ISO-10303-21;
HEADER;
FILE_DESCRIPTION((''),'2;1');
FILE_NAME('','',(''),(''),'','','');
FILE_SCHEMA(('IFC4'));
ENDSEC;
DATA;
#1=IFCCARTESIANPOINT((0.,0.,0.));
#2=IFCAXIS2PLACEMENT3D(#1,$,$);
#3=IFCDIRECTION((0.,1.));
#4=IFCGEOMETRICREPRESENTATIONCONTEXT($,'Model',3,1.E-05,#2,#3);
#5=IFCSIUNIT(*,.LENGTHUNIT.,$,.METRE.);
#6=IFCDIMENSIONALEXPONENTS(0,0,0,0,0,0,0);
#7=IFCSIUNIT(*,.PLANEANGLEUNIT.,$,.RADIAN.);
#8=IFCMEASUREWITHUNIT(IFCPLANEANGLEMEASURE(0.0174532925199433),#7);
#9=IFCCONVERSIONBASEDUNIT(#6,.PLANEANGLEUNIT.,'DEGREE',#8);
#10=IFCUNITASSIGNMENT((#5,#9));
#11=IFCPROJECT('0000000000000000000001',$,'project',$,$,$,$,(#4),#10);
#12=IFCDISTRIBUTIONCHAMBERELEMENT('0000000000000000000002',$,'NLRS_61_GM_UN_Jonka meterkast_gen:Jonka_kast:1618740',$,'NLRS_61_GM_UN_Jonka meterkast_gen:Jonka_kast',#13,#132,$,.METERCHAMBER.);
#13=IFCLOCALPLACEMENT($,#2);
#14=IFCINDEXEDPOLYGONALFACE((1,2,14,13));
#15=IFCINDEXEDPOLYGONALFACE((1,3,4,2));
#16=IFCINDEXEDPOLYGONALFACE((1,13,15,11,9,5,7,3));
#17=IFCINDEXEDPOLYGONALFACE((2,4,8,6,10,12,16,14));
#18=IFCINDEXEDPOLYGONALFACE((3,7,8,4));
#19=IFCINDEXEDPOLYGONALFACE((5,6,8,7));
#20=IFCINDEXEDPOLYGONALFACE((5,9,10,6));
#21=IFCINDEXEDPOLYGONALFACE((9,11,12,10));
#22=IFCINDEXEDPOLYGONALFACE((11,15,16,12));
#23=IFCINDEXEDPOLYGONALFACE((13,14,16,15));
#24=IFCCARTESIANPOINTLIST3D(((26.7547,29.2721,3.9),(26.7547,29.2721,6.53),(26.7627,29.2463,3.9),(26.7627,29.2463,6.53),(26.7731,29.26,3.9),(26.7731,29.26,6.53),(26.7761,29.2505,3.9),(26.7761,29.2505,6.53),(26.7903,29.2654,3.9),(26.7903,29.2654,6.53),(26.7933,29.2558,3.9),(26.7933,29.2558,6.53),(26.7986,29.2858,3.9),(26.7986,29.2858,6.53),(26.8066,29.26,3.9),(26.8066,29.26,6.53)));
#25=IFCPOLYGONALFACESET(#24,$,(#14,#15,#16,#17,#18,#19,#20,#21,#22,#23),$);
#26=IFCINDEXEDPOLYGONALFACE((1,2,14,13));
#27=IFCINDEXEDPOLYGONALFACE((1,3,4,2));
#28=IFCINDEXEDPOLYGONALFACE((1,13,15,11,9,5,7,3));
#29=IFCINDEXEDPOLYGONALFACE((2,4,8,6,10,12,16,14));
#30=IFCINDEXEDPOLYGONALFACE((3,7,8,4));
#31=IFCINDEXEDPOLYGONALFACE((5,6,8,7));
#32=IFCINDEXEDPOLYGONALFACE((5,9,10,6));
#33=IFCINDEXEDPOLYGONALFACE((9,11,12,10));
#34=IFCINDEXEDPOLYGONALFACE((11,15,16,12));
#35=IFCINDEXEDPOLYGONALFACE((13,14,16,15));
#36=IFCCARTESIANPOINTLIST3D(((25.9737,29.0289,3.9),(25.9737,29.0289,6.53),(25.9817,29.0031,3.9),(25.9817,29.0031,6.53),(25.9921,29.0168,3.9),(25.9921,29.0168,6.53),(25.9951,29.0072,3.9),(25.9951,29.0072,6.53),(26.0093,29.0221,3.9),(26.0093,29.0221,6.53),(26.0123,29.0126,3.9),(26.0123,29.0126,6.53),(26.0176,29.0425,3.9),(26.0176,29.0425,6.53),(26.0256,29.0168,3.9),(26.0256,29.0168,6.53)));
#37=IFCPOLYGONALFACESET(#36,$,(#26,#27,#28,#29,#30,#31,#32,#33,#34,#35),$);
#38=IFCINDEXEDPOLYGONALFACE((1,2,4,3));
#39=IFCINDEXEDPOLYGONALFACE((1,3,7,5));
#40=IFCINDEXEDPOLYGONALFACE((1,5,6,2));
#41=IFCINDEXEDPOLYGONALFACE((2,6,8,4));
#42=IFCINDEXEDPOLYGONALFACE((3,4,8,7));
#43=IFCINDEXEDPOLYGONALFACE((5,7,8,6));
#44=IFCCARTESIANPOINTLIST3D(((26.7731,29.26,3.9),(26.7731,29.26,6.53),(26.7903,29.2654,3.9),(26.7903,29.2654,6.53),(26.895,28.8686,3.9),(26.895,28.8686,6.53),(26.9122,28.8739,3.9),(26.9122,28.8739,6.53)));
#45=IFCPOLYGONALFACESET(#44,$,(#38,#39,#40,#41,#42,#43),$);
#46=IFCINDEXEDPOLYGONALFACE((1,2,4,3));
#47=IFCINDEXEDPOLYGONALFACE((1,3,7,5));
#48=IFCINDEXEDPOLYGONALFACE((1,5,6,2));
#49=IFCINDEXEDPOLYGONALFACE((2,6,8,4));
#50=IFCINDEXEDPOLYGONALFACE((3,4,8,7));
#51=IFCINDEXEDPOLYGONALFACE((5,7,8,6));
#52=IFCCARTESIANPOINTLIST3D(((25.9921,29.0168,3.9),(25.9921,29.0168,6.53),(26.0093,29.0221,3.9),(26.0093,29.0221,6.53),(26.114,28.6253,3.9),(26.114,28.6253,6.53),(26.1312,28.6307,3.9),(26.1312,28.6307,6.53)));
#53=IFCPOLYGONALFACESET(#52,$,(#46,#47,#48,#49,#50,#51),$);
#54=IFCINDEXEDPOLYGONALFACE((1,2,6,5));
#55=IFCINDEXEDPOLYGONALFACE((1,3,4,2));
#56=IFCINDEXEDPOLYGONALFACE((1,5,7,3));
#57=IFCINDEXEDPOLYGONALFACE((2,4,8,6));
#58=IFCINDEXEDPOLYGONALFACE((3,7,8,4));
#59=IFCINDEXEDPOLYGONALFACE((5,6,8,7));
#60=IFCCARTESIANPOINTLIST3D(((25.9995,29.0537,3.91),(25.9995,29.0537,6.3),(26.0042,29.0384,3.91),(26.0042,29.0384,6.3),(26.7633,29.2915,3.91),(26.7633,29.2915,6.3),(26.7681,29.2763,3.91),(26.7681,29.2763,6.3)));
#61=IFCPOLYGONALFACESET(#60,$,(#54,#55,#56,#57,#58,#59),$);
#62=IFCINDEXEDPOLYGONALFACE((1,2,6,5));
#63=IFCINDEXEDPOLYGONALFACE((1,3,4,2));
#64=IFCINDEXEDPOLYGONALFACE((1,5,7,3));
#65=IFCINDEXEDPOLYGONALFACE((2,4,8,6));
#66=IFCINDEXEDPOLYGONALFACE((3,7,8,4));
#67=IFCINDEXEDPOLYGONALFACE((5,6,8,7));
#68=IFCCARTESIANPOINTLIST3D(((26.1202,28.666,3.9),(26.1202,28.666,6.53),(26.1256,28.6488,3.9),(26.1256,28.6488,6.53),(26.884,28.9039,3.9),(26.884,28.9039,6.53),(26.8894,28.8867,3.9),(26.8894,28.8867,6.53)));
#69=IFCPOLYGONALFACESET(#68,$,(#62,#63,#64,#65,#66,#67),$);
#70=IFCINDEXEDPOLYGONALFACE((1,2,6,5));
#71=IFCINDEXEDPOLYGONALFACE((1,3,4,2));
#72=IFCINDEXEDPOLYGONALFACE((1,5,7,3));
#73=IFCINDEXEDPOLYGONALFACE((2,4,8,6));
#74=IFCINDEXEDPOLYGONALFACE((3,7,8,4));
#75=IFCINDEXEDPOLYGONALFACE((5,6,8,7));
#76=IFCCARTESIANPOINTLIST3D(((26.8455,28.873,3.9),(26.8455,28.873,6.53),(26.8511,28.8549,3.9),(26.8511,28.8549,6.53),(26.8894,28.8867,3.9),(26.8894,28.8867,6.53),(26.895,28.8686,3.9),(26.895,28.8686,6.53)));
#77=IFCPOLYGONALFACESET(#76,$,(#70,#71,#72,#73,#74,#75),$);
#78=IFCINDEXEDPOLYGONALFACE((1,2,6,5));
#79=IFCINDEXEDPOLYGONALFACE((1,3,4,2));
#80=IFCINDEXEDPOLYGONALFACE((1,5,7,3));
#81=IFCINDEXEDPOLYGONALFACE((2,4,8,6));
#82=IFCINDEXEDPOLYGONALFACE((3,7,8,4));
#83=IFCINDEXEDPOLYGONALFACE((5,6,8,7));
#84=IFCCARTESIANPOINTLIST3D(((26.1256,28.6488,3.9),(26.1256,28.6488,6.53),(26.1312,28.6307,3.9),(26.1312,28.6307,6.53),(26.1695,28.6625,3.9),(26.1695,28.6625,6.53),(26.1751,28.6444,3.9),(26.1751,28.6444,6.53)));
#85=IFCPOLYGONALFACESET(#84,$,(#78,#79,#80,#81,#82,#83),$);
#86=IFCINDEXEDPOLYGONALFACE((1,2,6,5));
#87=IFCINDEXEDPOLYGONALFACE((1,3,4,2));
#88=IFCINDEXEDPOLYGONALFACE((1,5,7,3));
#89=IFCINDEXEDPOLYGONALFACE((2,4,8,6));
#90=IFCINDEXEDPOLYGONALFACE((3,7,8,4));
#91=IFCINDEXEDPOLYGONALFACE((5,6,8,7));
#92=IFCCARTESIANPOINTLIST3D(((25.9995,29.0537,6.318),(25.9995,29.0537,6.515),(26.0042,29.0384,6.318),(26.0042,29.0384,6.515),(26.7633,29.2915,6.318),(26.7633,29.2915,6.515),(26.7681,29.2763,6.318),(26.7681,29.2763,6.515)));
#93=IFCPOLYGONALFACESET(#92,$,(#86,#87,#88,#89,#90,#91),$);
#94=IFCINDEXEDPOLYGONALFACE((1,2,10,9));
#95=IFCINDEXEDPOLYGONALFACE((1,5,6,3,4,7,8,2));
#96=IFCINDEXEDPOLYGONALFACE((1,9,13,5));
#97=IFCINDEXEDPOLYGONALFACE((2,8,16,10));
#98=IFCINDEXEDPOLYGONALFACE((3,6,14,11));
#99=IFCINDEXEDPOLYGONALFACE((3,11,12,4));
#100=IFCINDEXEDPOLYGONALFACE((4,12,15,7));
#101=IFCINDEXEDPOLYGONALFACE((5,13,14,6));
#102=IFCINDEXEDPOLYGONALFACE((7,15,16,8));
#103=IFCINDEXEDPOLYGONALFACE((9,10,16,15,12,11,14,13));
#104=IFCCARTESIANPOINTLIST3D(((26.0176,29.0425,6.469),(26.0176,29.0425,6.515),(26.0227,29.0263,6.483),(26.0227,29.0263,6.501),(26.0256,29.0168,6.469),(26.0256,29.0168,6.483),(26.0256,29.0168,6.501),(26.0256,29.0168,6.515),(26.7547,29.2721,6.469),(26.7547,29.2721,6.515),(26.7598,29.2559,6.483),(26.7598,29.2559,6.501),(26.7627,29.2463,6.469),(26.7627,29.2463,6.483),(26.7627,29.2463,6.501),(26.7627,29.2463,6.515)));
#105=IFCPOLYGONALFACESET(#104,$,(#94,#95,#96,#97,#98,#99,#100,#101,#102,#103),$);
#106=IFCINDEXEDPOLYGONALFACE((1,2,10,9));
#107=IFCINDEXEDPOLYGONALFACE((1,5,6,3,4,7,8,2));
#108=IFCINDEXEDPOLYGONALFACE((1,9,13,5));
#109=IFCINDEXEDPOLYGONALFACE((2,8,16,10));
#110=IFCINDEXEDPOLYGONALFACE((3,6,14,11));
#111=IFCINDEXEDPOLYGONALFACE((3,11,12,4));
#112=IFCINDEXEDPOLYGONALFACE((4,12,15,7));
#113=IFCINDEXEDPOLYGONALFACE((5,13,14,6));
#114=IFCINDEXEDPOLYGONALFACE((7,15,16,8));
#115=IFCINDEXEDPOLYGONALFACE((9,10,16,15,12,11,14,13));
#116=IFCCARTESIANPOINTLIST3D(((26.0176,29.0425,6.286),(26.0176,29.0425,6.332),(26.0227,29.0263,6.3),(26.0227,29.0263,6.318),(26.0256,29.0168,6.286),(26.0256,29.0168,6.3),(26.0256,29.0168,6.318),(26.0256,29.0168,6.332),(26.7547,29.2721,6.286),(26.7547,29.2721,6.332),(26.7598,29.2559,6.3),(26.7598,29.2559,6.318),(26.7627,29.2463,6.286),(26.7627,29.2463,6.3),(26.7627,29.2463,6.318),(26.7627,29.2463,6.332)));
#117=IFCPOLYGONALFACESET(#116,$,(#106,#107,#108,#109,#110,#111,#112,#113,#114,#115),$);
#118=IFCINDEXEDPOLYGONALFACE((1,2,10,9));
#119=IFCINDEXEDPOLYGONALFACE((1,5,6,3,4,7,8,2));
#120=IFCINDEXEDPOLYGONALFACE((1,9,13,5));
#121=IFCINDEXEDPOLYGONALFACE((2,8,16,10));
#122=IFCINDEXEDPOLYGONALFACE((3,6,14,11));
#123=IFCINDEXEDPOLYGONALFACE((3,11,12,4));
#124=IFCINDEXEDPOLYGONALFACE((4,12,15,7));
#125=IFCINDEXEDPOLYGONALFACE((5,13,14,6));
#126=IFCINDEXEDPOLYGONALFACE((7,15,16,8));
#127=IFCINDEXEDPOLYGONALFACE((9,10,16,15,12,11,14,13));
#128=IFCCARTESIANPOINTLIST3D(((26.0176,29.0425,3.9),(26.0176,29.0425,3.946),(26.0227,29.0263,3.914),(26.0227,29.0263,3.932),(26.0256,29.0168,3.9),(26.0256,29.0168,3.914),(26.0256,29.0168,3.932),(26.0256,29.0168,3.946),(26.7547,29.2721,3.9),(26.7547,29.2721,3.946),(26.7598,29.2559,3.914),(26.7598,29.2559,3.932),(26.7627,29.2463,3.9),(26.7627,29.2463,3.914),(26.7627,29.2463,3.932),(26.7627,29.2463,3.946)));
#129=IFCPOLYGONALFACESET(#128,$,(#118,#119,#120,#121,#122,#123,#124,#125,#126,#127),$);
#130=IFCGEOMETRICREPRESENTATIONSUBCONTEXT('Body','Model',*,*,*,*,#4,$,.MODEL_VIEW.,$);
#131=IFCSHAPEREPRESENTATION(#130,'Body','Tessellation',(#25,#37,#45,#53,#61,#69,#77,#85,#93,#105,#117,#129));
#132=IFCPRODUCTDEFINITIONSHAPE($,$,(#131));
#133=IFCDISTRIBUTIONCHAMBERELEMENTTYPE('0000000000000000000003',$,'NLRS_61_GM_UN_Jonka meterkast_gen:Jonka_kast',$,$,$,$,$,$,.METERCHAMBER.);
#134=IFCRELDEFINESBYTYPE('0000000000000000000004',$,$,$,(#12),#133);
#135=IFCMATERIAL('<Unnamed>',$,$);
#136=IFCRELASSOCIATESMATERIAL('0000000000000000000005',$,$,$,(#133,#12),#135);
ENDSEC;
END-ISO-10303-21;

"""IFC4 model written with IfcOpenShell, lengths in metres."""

from ifc_helpers import new_model, entity, si_unit, converted_unit, direction, frame, origin, place, context, subcontext, project, indexed_curve, outline, extrude, source, transform, mapped, material, type_object, type_shapes, element, save


model = new_model("IFC4")

# Units and contexts
model_context = context("Model", 3, precision=1e-05, world=origin(), true_north=direction((0.0, 1.0)))
body_context = subcontext(model_context, "Body", "Model", "MODEL_VIEW")
ifc_project = project(units=[si_unit("LENGTHUNIT", "METRE"), converted_unit("PLANEANGLEUNIT", "DEGREE", entity("IfcPlaneAngleMeasure", 0.0174532925199433), si_unit("PLANEANGLEUNIT", "RADIAN"), dimensions=[0, 0, 0, 0, 0, 0, 0])], contexts=[model_context])

# Distribution chamber element
ifc_material = material(Name="<Unnamed>")
distribution_chamber_element_type = type_object("IfcDistributionChamberElementType", Name="NLRS_61_GM_UN_Jonka meterkast_gen:Jonka_kast", PredefinedType="METERCHAMBER", material=ifc_material)
shared_shape_1 = source(origin(), body_context, "Body", "SweptSolid", [
    extrude(outline(indexed_curve([(-0.0093, -0.023), (0.0178, -0.023), (0.0178, 0.023), (-0.0093, 0.023), (-0.0093, 0.009), (0.0007, 0.009), (0.0007, -0.009), (-0.0093, -0.009), (-0.0093, -0.023)], self_intersect=False)), frame((-0.409, -0.4092, 0.0), z_axis=(0.0, 0.0, 1.0), x_axis=(0.0, -1.0, 0.0)), (0.0, 0.0, 1.0), 2.63),
    extrude(outline(indexed_curve([(-0.0093, -0.023), (0.0178, -0.023), (0.0178, 0.023), (-0.0093, 0.023), (-0.0093, 0.009), (0.0007, 0.009), (0.0007, -0.009), (-0.0093, -0.009), (-0.0093, -0.023)], self_intersect=False)), frame((0.409, -0.4092, 0.0), z_axis=(0.0, 0.0, 1.0), x_axis=(0.0, -1.0, 0.0)), (0.0, 0.0, 1.0), 2.63),
    extrude(outline(indexed_curve([(-0.205, -0.009), (0.205, -0.009), (0.205, 0.009), (-0.205, 0.009), (-0.205, -0.009)], self_intersect=False)), frame((-0.409, -0.205, 0.0), z_axis=(0.0, 0.0, 1.0), x_axis=(0.0, -1.0, 0.0)), (0.0, 0.0, 1.0), 2.63),
    extrude(outline(indexed_curve([(-0.205, -0.009), (0.205, -0.009), (0.205, 0.009), (-0.205, 0.009), (-0.205, -0.009)], self_intersect=False)), frame((0.409, -0.205, 0.0), z_axis=(0.0, 0.0, 1.0), x_axis=(0.0, -1.0, 0.0)), (0.0, 0.0, 1.0), 2.63),
    extrude(outline(indexed_curve([(-0.4, -0.008), (0.4, -0.008), (0.4, 0.008), (-0.4, 0.008), (-0.4, -0.008)], self_intersect=False)), frame((0.0, -0.435, 0.01), z_axis=(0.0, 0.0, 1.0), x_axis=(-1.0, 0.0, 0.0)), (0.0, 0.0, 1.0), 2.39),
    extrude(outline(indexed_curve([(-0.4, -0.009), (0.4, -0.009), (0.4, 0.009), (-0.4, 0.009), (-0.4, -0.009)], self_intersect=False)), frame((0.0, -0.028, 0.0), z_axis=(0.0, 0.0, 1.0), x_axis=(-1.0, 0.0, 0.0)), (0.0, 0.0, 1.0), 2.63),
    extrude(outline(indexed_curve([(-0.023, -0.0095), (0.023, -0.0095), (0.023, 0.0095), (-0.023, 0.0095), (-0.023, -0.0095)], self_intersect=False)), frame((-0.377, -0.0095, 0.0), z_axis=(0.0, 0.0, 1.0), x_axis=(-1.0, 0.0, 0.0)), (0.0, 0.0, 1.0), 2.63),
    extrude(outline(indexed_curve([(-0.023, -0.0095), (0.023, -0.0095), (0.023, 0.0095), (-0.023, 0.0095), (-0.023, -0.0095)], self_intersect=False)), frame((0.377, -0.0095, 0.0), z_axis=(0.0, 0.0, 1.0), x_axis=(-1.0, 0.0, 0.0)), (0.0, 0.0, 1.0), 2.63),
    extrude(outline(indexed_curve([(-0.4, -0.008), (0.4, -0.008), (0.4, 0.008), (-0.4, 0.008), (-0.4, -0.008)], self_intersect=False)), frame((0.0, -0.435, 2.418), z_axis=(0.0, 0.0, 1.0), x_axis=(-1.0, 0.0, 0.0)), (0.0, 0.0, 1.0), 0.197),
    extrude(outline(indexed_curve([(-0.023, -0.0178), (0.023, -0.0178), (0.023, 0.0093), (0.009, 0.0093), (0.009, -0.0007), (-0.009, -0.0007), (-0.009, 0.0093), (-0.023, 0.0093), (-0.023, -0.0178)], self_intersect=False)), frame((-0.386, -0.4092, 2.592), z_axis=(1.0, 0.0, 0.0), x_axis=(0.0, 0.0, -1.0)), (0.0, 0.0, 1.0), 0.772),
    extrude(outline(indexed_curve([(-0.023, -0.0178), (0.023, -0.0178), (0.023, 0.0093), (0.009, 0.0093), (0.009, -0.0007), (-0.009, -0.0007), (-0.009, 0.0093), (-0.023, 0.0093), (-0.023, -0.0178)], self_intersect=False)), frame((-0.386, -0.4092, 2.409), z_axis=(1.0, 0.0, 0.0), x_axis=(0.0, 0.0, -1.0)), (0.0, 0.0, 1.0), 0.772),
    extrude(outline(indexed_curve([(-0.023, -0.0178), (0.023, -0.0178), (0.023, 0.0093), (0.009, 0.0093), (0.009, -0.0007), (-0.009, -0.0007), (-0.009, 0.0093), (-0.023, 0.0093), (-0.023, -0.0178)], self_intersect=False)), frame((-0.386, -0.4092, 0.023), z_axis=(1.0, 0.0, 0.0), x_axis=(0.0, 0.0, -1.0)), (0.0, 0.0, 1.0), 0.772),
])
type_shapes(distribution_chamber_element_type, [shared_shape_1])
placement_1 = place(None, frame((13.1348, 11.9886, 0.0), z_axis=(0.0, 0.0, 1.0), x_axis=(0.954771, 0.297342, 0.0)))
placement_2 = place(placement_1, origin())
placement_3 = place(placement_2, frame((0.0, 0.0, 3.9)))
placement_4 = place(placement_3, origin())
distribution_chamber_element_1_placement = place(placement_4, frame((17.757, 12.025, 0.0), z_axis=(0.0, 0.0, 1.0), x_axis=(-1.0, 0.0, 0.0)))
element("IfcDistributionChamberElement", 1, at=distribution_chamber_element_1_placement, type_object=distribution_chamber_element_type, material=ifc_material, Name="NLRS_61_GM_UN_Jonka meterkast_gen:Jonka_kast:1618740", ObjectType="NLRS_61_GM_UN_Jonka meterkast_gen:Jonka_kast", PredefinedType="METERCHAMBER", context=body_context, shape_type="MappedRepresentation", body=[
    mapped(shared_shape_1, transform((0.0, 0.0, 0.0), scale=1.0)),
])

save(model, "model.ifc")
